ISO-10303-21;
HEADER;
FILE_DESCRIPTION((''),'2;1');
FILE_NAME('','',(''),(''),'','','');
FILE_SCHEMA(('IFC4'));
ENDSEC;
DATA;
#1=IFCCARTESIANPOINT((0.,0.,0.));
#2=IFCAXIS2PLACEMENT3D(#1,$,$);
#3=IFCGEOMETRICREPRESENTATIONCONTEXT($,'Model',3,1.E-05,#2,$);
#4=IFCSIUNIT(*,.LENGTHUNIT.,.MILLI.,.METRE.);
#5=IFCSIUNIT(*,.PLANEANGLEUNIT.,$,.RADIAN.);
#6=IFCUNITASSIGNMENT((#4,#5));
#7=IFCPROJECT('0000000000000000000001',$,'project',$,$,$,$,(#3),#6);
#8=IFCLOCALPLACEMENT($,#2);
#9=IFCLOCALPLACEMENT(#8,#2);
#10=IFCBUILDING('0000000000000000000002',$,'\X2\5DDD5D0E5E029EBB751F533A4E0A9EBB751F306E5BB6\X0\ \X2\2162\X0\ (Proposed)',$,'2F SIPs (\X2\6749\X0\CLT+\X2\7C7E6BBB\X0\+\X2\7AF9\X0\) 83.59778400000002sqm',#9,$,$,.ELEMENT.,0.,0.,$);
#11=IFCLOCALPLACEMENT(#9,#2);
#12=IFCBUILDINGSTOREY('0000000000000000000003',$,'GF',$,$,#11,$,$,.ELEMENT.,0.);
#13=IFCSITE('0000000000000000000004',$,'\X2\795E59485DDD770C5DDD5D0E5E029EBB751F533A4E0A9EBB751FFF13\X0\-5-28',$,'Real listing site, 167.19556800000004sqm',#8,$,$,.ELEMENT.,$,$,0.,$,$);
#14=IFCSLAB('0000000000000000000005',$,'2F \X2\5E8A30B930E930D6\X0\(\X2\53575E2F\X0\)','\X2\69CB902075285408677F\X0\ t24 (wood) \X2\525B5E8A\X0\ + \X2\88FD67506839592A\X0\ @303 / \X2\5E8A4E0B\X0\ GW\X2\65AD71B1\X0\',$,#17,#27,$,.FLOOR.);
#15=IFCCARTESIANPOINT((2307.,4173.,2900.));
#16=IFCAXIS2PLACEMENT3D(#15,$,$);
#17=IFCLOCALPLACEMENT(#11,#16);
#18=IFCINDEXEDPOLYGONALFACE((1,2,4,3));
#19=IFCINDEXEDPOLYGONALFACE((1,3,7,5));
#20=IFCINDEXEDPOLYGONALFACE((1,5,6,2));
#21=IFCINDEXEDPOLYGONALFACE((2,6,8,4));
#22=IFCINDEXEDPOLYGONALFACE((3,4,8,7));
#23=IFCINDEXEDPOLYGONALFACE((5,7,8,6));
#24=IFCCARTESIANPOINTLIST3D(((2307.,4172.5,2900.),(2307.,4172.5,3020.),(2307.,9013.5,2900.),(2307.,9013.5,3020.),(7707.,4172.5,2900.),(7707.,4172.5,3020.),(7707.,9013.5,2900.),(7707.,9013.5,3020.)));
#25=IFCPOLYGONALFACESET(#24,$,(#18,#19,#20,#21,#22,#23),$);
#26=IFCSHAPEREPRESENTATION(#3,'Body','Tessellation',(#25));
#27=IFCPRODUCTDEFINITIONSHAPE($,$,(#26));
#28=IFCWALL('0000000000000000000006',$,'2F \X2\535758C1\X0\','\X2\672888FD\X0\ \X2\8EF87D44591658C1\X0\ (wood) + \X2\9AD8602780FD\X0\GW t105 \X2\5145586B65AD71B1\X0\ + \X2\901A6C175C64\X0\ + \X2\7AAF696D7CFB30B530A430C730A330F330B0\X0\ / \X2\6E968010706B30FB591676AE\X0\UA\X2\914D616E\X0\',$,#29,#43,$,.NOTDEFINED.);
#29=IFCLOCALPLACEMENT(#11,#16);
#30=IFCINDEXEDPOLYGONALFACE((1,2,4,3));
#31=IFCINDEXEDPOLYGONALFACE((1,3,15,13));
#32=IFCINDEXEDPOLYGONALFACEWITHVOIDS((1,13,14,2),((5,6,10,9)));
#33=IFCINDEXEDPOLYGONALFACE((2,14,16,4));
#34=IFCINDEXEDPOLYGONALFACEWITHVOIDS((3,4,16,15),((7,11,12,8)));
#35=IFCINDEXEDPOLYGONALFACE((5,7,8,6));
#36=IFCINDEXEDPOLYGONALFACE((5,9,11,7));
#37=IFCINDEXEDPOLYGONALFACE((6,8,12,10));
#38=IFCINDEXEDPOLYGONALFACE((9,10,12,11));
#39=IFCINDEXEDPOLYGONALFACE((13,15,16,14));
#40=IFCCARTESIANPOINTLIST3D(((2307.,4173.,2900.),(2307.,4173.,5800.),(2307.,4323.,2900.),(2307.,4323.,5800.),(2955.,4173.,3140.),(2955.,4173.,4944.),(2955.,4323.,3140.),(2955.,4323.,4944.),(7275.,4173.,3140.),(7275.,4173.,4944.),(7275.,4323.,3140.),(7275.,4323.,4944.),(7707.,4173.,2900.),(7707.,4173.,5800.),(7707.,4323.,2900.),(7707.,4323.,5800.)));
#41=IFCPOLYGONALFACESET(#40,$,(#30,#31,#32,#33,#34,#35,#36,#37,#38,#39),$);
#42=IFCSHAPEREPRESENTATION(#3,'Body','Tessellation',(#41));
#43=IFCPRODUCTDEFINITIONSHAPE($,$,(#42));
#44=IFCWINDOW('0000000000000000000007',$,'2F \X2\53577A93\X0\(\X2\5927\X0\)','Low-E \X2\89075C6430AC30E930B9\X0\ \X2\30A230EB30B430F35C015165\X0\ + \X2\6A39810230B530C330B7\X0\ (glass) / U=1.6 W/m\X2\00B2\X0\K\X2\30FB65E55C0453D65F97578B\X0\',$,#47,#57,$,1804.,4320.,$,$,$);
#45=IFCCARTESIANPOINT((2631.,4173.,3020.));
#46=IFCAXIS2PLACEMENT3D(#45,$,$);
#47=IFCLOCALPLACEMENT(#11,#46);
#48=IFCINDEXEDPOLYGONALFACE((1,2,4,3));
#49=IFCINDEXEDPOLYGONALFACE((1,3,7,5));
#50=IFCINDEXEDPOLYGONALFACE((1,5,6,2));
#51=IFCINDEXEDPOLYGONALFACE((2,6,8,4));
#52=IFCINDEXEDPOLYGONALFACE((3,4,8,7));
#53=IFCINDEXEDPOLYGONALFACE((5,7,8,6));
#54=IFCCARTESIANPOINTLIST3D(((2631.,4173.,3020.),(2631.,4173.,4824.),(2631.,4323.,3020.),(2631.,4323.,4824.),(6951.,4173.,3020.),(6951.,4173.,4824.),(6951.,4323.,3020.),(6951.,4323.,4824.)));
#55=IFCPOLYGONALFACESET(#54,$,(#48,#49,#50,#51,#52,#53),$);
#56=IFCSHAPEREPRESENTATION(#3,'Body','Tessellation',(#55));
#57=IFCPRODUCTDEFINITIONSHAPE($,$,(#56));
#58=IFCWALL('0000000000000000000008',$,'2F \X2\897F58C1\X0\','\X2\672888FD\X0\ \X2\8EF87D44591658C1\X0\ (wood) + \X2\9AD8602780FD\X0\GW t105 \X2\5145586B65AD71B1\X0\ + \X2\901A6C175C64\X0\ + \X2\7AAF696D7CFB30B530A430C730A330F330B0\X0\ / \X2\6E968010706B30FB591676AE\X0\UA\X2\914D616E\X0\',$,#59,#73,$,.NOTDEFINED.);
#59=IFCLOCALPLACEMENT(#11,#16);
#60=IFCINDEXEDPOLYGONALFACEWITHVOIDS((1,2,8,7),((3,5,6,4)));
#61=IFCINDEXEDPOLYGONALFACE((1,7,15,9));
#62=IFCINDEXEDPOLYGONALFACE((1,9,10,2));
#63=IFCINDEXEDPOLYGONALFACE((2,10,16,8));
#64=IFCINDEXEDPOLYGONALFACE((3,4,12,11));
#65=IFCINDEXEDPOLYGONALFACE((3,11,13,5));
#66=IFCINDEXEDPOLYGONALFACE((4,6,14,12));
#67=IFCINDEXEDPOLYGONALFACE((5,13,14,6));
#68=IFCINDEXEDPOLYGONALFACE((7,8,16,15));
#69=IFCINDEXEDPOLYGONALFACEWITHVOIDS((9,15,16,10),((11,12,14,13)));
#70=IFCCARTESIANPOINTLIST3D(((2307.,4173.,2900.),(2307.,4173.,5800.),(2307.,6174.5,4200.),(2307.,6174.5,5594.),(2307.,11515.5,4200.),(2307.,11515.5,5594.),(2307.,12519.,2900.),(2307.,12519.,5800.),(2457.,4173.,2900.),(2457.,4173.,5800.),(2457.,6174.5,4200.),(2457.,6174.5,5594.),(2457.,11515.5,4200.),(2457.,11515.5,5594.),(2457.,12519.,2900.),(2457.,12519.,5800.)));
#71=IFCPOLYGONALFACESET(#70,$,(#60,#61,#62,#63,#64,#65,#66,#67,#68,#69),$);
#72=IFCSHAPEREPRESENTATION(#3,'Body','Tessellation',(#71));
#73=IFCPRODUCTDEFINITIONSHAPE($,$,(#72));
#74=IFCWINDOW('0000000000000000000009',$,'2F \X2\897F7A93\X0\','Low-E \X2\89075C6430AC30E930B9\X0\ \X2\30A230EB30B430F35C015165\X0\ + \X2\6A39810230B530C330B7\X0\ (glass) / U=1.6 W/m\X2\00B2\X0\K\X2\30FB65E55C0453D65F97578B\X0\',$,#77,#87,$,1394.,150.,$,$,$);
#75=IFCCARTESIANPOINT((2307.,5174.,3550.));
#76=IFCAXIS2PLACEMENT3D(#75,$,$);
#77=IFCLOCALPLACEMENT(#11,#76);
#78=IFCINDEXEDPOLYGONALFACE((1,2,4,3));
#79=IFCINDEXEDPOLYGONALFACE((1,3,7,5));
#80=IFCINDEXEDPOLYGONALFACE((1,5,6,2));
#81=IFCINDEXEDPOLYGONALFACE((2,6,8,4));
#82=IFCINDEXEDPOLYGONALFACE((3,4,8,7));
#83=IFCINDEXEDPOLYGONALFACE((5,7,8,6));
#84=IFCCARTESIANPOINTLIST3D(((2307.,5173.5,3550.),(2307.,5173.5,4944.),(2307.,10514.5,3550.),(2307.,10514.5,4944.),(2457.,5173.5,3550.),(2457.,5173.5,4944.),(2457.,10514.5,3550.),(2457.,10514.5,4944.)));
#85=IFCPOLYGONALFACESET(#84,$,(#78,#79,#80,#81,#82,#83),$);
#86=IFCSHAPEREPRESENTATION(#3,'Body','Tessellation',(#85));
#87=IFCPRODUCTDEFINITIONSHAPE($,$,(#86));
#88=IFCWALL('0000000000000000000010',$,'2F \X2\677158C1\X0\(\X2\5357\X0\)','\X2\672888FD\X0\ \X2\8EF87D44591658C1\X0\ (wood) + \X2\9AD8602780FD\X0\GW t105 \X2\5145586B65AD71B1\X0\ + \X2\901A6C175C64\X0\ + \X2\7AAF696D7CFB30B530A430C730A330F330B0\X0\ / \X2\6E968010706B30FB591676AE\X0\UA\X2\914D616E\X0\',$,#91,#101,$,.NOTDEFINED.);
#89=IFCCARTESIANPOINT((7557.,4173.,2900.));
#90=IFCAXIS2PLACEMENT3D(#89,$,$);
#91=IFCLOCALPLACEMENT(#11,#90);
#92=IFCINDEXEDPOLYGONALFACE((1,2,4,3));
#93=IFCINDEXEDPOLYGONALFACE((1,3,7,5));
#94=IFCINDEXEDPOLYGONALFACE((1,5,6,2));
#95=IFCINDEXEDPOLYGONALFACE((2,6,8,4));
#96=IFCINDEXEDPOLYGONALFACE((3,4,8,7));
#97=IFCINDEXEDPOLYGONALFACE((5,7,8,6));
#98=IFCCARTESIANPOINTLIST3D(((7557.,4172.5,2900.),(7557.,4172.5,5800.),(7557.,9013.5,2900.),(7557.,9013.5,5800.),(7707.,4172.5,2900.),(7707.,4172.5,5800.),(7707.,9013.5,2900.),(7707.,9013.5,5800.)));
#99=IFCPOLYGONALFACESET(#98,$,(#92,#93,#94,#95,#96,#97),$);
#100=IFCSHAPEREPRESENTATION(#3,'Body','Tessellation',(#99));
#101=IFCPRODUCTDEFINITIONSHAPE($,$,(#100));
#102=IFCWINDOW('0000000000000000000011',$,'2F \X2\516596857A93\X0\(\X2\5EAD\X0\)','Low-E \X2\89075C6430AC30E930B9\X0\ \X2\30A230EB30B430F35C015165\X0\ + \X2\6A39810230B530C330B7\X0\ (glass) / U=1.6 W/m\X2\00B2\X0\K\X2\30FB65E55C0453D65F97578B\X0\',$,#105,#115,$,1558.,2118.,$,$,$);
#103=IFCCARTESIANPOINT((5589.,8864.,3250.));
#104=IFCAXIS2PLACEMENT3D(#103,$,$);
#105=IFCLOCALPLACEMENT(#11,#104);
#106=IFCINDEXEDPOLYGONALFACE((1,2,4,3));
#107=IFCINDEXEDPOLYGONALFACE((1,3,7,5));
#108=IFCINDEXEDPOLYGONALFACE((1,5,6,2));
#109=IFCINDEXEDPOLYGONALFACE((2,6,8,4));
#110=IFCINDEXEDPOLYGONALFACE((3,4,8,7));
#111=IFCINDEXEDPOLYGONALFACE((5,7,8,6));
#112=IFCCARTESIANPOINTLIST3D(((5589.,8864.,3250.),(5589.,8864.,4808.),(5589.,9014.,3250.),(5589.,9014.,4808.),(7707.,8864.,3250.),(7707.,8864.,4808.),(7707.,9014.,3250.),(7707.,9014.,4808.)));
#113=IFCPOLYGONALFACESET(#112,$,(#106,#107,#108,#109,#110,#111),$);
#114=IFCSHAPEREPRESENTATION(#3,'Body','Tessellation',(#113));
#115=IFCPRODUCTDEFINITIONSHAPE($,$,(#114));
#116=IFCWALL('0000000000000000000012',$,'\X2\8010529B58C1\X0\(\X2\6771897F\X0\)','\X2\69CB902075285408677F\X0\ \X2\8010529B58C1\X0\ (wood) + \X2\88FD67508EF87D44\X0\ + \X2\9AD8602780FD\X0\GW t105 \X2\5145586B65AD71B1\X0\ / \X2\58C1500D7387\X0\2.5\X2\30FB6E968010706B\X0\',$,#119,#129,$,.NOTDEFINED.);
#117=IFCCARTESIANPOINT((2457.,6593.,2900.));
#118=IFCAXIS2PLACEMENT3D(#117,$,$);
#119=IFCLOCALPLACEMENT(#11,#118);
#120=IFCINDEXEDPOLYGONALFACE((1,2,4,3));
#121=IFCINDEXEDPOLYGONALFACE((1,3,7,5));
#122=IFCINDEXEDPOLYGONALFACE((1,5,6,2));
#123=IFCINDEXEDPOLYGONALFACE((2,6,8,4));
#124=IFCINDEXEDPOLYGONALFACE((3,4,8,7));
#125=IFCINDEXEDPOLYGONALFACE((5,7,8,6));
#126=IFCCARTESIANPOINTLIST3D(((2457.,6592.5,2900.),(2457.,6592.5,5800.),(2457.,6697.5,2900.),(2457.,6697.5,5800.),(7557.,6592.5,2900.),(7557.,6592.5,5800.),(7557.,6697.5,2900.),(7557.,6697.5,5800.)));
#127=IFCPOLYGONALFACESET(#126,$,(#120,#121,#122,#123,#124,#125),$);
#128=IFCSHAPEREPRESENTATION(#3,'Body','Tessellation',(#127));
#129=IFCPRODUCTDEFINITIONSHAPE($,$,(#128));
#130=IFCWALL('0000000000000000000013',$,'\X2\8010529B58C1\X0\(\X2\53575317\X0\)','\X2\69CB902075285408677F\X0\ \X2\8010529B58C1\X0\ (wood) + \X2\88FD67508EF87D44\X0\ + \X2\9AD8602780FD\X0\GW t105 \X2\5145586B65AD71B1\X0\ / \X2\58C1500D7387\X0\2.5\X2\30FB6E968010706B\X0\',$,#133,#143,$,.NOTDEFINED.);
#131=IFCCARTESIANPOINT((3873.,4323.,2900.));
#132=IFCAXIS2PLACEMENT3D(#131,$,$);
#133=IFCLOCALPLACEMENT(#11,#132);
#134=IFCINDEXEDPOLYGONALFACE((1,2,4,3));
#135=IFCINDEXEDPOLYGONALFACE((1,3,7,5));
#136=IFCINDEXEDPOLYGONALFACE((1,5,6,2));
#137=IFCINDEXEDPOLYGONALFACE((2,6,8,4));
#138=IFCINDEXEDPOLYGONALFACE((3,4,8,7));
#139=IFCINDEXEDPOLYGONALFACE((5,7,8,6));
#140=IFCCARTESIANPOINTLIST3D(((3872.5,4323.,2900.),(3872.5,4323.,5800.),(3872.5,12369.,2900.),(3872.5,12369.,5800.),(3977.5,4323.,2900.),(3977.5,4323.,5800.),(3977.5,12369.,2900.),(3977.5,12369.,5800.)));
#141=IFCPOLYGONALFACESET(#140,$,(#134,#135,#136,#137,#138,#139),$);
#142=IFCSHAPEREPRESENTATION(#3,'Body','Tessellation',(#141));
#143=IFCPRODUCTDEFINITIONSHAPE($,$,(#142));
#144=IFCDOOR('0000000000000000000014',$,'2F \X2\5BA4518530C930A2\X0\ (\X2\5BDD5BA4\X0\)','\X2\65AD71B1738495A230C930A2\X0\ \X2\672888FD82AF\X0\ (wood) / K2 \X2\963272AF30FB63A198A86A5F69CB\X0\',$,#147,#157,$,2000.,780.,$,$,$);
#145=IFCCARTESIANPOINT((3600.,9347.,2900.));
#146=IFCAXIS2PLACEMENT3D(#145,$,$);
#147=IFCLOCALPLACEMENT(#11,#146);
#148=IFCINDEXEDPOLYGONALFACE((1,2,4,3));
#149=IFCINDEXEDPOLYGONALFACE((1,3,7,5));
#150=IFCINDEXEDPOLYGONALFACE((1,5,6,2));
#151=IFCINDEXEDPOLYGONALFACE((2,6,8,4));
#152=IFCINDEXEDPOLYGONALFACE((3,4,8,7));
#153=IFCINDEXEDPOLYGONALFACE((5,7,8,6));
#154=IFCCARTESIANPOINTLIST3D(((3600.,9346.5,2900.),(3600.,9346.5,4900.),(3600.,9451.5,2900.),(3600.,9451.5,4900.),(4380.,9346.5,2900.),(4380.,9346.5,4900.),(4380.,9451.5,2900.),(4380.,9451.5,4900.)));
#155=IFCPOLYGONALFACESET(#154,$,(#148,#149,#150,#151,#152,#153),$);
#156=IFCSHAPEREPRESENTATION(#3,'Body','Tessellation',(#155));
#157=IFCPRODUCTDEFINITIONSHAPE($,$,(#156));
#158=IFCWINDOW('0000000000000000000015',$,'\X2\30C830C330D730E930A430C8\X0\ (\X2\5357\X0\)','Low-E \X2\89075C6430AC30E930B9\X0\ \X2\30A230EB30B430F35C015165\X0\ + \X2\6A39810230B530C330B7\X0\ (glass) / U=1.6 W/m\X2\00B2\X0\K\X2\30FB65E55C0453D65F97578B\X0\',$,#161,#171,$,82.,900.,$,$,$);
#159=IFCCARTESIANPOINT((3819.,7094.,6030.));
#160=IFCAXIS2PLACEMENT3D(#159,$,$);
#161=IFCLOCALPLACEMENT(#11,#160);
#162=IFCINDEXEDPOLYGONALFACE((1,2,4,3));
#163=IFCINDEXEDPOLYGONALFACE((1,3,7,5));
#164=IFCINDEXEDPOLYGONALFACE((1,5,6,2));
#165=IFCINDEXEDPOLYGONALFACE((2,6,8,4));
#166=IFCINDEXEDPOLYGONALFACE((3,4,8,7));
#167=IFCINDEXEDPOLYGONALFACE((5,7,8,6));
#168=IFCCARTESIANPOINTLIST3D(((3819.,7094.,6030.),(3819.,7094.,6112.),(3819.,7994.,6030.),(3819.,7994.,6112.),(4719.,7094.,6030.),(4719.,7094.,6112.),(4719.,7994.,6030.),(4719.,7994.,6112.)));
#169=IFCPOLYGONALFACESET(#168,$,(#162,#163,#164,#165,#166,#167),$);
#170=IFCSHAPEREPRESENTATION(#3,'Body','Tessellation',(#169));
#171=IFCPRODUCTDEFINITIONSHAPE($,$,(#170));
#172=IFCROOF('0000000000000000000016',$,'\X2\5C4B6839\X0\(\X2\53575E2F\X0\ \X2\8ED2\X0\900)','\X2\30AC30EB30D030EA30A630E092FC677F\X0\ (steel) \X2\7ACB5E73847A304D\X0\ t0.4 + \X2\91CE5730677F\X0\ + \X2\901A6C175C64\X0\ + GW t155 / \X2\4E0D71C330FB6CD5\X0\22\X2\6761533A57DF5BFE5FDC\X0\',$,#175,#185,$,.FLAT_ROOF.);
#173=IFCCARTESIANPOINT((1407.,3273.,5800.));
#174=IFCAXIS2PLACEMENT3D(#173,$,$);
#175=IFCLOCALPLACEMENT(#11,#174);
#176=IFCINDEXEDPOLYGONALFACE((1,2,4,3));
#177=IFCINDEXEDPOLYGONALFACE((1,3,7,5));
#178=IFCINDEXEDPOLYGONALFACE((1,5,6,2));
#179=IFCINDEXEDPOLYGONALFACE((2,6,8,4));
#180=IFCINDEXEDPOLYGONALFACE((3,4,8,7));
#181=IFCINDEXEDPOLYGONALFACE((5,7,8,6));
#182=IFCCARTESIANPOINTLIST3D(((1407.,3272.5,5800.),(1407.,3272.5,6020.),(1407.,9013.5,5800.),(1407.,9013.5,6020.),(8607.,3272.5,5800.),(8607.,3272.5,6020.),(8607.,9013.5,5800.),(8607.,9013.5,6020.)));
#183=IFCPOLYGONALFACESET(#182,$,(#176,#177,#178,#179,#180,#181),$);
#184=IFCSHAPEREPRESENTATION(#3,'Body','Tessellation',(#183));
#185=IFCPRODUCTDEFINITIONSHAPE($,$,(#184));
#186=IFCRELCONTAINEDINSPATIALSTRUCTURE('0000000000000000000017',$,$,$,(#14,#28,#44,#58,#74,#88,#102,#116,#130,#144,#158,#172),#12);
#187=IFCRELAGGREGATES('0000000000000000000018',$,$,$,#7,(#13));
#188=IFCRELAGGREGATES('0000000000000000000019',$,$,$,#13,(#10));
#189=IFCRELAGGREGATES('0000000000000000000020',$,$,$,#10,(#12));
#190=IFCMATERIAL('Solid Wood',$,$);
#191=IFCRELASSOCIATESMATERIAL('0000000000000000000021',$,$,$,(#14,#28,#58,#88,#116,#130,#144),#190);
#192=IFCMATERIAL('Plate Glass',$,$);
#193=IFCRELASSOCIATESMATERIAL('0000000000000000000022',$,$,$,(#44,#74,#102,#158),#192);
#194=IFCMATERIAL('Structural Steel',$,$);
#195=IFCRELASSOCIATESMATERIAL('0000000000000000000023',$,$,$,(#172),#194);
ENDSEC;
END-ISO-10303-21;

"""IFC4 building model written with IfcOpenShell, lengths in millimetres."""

from ifc_helpers import new_model, si_unit, frame, frame_2d, origin, place, context, project, spatial, rectangle, extrude, material, element, fill, save


model = new_model("IFC4")

# Units and contexts
model_context = context("Model", 3, precision=1e-05, world=origin())
ifc_project = project(units=[si_unit("LENGTHUNIT", "METRE", prefix="MILLI"), si_unit("PLANEANGLEUNIT", "RADIAN")], contexts=[model_context])

# Site, building, storey
site_placement = place(None, origin())
site = spatial("IfcSite", under=ifc_project, at=site_placement, Name="神奈川県川崎市麻生区上麻生３-5-28", ObjectType="Real listing site, 167.19556800000004sqm", CompositionType="ELEMENT", RefElevation=0.0)
building_placement = place(site_placement, origin())
building = spatial("IfcBuilding", under=site, at=building_placement, Name="川崎市麻生区上麻生の家 Ⅲ (Proposed)", ObjectType="2F SIPs (杉CLT+籾殻+竹) 83.59778400000002sqm", CompositionType="ELEMENT", ElevationOfRefHeight=0.0, ElevationOfTerrain=0.0)
storey_placement = place(building_placement, origin())
storey = spatial("IfcBuildingStorey", under=building, at=storey_placement, Name="GF", CompositionType="ELEMENT", Elevation=0.0)

# Slab
ifc_material_1 = material(Name="Solid Wood")
slab_placement = place(storey_placement, frame((2307.0, 4173.0, 2900.0)))
element("IfcSlab", 1, at=slab_placement, inside=storey, material=ifc_material_1, Name="2F 床スラブ(南帯)", Description="構造用合板 t24 (wood) 剛床 + 製材根太 @303 / 床下 GW断熱", PredefinedType="FLOOR", context=model_context, shape_type="SweptSolid", body=[
    extrude(rectangle(XDim=5400.0, YDim=4841.0, at=frame_2d((2700.0, 2420.0))), frame((2307.0, 4173.0, 2900.0)), (0.0, 0.0, 1.0), 120.0),
])

# Walls, openings, windows
wall_1_placement = place(storey_placement, frame((2307.0, 4173.0, 2900.0)))
wall_1 = element("IfcWall", 2, at=wall_1_placement, inside=storey, material=ifc_material_1, Name="2F 南壁", Description="木製 軸組外壁 (wood) + 高性能GW t105 充填断熱 + 通気層 + 窯業系サイディング / 準耐火・外皮UA配慮", PredefinedType="NOTDEFINED", context=model_context, shape_type="SweptSolid", body=[
    extrude(rectangle(XDim=5400.0, YDim=150.0, at=frame_2d((2700.0, 75.0))), frame((2307.0, 4173.0, 2900.0)), (0.0, 0.0, 1.0), 2900.0),
])
opening_1_placement = place(storey_placement, frame((2631.0, 4173.0, 3020.0)))
opening_1 = element("IfcOpeningElement", 3, at=opening_1_placement, cuts=wall_1, PredefinedType="NOTDEFINED", context=model_context, shape_type="SweptSolid", body=[
    extrude(rectangle(XDim=4320.0, YDim=150.0, at=frame_2d((2160.0, 75.0))), frame((2631.0, 4173.0, 3020.0)), (0.0, 0.0, 1.0), 1804.0),
])
ifc_material_2 = material(Name="Plate Glass")
window_1_placement = place(storey_placement, frame((2631.0, 4173.0, 3020.0)))
window_1 = element("IfcWindow", 4, at=window_1_placement, inside=storey, material=ifc_material_2, Name="2F 南窓(大)", Description="Low-E 複層ガラス アルゴン封入 + 樹脂サッシ (glass) / U=1.6 W/m²K・日射取得型", OverallHeight=1804.0, OverallWidth=4320.0, context=model_context, shape_type="SweptSolid", body=[
    extrude(rectangle(XDim=4320.0, YDim=150.0, at=frame_2d((2160.0, 75.0))), frame((2631.0, 4173.0, 3020.0)), (0.0, 0.0, 1.0), 1804.0),
])
fill(opening_1, window_1)
wall_2_placement = place(storey_placement, frame((2307.0, 4173.0, 2900.0)))
wall_2 = element("IfcWall", 5, at=wall_2_placement, inside=storey, material=ifc_material_1, Name="2F 西壁", Description="木製 軸組外壁 (wood) + 高性能GW t105 充填断熱 + 通気層 + 窯業系サイディング / 準耐火・外皮UA配慮", PredefinedType="NOTDEFINED", context=model_context, shape_type="SweptSolid", body=[
    extrude(rectangle(XDim=150.0, YDim=8346.0, at=frame_2d((75.0, 4173.0))), frame((2307.0, 4173.0, 2900.0)), (0.0, 0.0, 1.0), 2900.0),
])
opening_2_placement = place(storey_placement, frame((2307.0, 5174.0, 3550.0)))
opening_2 = element("IfcOpeningElement", 6, at=opening_2_placement, cuts=wall_2, PredefinedType="NOTDEFINED", context=model_context, shape_type="SweptSolid", body=[
    extrude(rectangle(XDim=150.0, YDim=5341.0, at=frame_2d((75.0, 2670.0))), frame((2307.0, 5174.0, 3550.0)), (0.0, 0.0, 1.0), 1394.0),
])
window_2_placement = place(storey_placement, frame((2307.0, 5174.0, 3550.0)))
window_2 = element("IfcWindow", 7, at=window_2_placement, inside=storey, material=ifc_material_2, Name="2F 西窓", Description="Low-E 複層ガラス アルゴン封入 + 樹脂サッシ (glass) / U=1.6 W/m²K・日射取得型", OverallHeight=1394.0, OverallWidth=150.0, context=model_context, shape_type="SweptSolid", body=[
    extrude(rectangle(XDim=150.0, YDim=5341.0, at=frame_2d((75.0, 2670.0))), frame((2307.0, 5174.0, 3550.0)), (0.0, 0.0, 1.0), 1394.0),
])
fill(opening_2, window_2)
wall_3_placement = place(storey_placement, frame((7557.0, 4173.0, 2900.0)))
wall_3 = element("IfcWall", 8, at=wall_3_placement, inside=storey, material=ifc_material_1, Name="2F 東壁(南)", Description="木製 軸組外壁 (wood) + 高性能GW t105 充填断熱 + 通気層 + 窯業系サイディング / 準耐火・外皮UA配慮", PredefinedType="NOTDEFINED", context=model_context, shape_type="SweptSolid", body=[
    extrude(rectangle(XDim=150.0, YDim=4841.0, at=frame_2d((75.0, 2420.0))), frame((7557.0, 4173.0, 2900.0)), (0.0, 0.0, 1.0), 2900.0),
])
opening_3_placement = place(storey_placement, frame((5589.0, 8864.0, 3250.0)))
opening_3 = element("IfcOpeningElement", 9, at=opening_3_placement, cuts=wall_3, PredefinedType="NOTDEFINED", context=model_context, shape_type="SweptSolid", body=[
    extrude(rectangle(XDim=2118.0, YDim=150.0, at=frame_2d((1059.0, 75.0))), frame((5589.0, 8864.0, 3250.0)), (0.0, 0.0, 1.0), 1558.0),
])
window_3_placement = place(storey_placement, frame((5589.0, 8864.0, 3250.0)))
window_3 = element("IfcWindow", 10, at=window_3_placement, inside=storey, material=ifc_material_2, Name="2F 入隅窓(庭)", Description="Low-E 複層ガラス アルゴン封入 + 樹脂サッシ (glass) / U=1.6 W/m²K・日射取得型", OverallHeight=1558.0, OverallWidth=2118.0, context=model_context, shape_type="SweptSolid", body=[
    extrude(rectangle(XDim=2118.0, YDim=150.0, at=frame_2d((1059.0, 75.0))), frame((5589.0, 8864.0, 3250.0)), (0.0, 0.0, 1.0), 1558.0),
])
fill(opening_3, window_3)

# Wall
wall_4_placement = place(storey_placement, frame((2457.0, 6593.0, 2900.0)))
element("IfcWall", 11, at=wall_4_placement, inside=storey, material=ifc_material_1, Name="耐力壁(東西)", Description="構造用合板 耐力壁 (wood) + 製材軸組 + 高性能GW t105 充填断熱 / 壁倍率2.5・準耐火", PredefinedType="NOTDEFINED", context=model_context, shape_type="SweptSolid", body=[
    extrude(rectangle(XDim=5100.0, YDim=105.0, at=frame_2d((2550.0, 52.0))), frame((2457.0, 6593.0, 2900.0)), (0.0, 0.0, 1.0), 2900.0),
])

# Wall, opening, door
wall_5_placement = place(storey_placement, frame((3873.0, 4323.0, 2900.0)))
wall_5 = element("IfcWall", 12, at=wall_5_placement, inside=storey, material=ifc_material_1, Name="耐力壁(南北)", Description="構造用合板 耐力壁 (wood) + 製材軸組 + 高性能GW t105 充填断熱 / 壁倍率2.5・準耐火", PredefinedType="NOTDEFINED", context=model_context, shape_type="SweptSolid", body=[
    extrude(rectangle(XDim=105.0, YDim=8046.0, at=frame_2d((52.0, 4023.0))), frame((3873.0, 4323.0, 2900.0)), (0.0, 0.0, 1.0), 2900.0),
])
opening_4_placement = place(storey_placement, frame((3600.0, 9347.0, 2900.0)))
opening_4 = element("IfcOpeningElement", 13, at=opening_4_placement, cuts=wall_5, PredefinedType="NOTDEFINED", context=model_context, shape_type="SweptSolid", body=[
    extrude(rectangle(XDim=780.0, YDim=105.0, at=frame_2d((390.0, 52.0))), frame((3600.0, 9347.0, 2900.0)), (0.0, 0.0, 1.0), 2000.0),
])
door_placement = place(storey_placement, frame((3600.0, 9347.0, 2900.0)))
door = element("IfcDoor", 14, at=door_placement, inside=storey, material=ifc_material_1, Name="2F 室内ドア (寝室)", Description="断熱玄関ドア 木製芯 (wood) / K2 防犯・採風機構", OverallHeight=2000.0, OverallWidth=780.0, context=model_context, shape_type="SweptSolid", body=[
    extrude(rectangle(XDim=780.0, YDim=105.0, at=frame_2d((390.0, 52.0))), frame((3600.0, 9347.0, 2900.0)), (0.0, 0.0, 1.0), 2000.0),
])
fill(opening_4, door)

# Window
window_4_placement = place(storey_placement, frame((3819.0, 7094.0, 6030.0)))
element("IfcWindow", 15, at=window_4_placement, inside=storey, material=ifc_material_2, Name="トップライト (南)", Description="Low-E 複層ガラス アルゴン封入 + 樹脂サッシ (glass) / U=1.6 W/m²K・日射取得型", OverallHeight=82.0, OverallWidth=900.0, context=model_context, shape_type="SweptSolid", body=[
    extrude(rectangle(XDim=900.0, YDim=900.0, at=frame_2d((450.0, 450.0))), frame((3819.0, 7094.0, 6030.0)), (0.0, 0.0, 1.0), 82.0),
])

# Roof
ifc_material_3 = material(Name="Structural Steel")
for number, where, name in (
    (16, (1407.0, 3273.0, 5800.0), "屋根(南帯 軒900)"),
):
    element("IfcRoof", number, at=place(storey_placement, frame(where)), inside=storey, material=ifc_material_3, Name=name, Description="ガルバリウム鋼板 (steel) 立平葺き t0.4 + 野地板 + 通気層 + GW t155 / 不燃・法22条区域対応", PredefinedType="FLAT_ROOF", context=model_context, shape_type="SweptSolid", body=[
        extrude(rectangle(XDim=7200.0, YDim=5741.0, at=frame_2d((3600.0, 2870.0))), frame((1407.0, 3273.0, 5800.0)), (0.0, 0.0, 1.0), 220.0),
    ])

save(model, "model.ifc")
